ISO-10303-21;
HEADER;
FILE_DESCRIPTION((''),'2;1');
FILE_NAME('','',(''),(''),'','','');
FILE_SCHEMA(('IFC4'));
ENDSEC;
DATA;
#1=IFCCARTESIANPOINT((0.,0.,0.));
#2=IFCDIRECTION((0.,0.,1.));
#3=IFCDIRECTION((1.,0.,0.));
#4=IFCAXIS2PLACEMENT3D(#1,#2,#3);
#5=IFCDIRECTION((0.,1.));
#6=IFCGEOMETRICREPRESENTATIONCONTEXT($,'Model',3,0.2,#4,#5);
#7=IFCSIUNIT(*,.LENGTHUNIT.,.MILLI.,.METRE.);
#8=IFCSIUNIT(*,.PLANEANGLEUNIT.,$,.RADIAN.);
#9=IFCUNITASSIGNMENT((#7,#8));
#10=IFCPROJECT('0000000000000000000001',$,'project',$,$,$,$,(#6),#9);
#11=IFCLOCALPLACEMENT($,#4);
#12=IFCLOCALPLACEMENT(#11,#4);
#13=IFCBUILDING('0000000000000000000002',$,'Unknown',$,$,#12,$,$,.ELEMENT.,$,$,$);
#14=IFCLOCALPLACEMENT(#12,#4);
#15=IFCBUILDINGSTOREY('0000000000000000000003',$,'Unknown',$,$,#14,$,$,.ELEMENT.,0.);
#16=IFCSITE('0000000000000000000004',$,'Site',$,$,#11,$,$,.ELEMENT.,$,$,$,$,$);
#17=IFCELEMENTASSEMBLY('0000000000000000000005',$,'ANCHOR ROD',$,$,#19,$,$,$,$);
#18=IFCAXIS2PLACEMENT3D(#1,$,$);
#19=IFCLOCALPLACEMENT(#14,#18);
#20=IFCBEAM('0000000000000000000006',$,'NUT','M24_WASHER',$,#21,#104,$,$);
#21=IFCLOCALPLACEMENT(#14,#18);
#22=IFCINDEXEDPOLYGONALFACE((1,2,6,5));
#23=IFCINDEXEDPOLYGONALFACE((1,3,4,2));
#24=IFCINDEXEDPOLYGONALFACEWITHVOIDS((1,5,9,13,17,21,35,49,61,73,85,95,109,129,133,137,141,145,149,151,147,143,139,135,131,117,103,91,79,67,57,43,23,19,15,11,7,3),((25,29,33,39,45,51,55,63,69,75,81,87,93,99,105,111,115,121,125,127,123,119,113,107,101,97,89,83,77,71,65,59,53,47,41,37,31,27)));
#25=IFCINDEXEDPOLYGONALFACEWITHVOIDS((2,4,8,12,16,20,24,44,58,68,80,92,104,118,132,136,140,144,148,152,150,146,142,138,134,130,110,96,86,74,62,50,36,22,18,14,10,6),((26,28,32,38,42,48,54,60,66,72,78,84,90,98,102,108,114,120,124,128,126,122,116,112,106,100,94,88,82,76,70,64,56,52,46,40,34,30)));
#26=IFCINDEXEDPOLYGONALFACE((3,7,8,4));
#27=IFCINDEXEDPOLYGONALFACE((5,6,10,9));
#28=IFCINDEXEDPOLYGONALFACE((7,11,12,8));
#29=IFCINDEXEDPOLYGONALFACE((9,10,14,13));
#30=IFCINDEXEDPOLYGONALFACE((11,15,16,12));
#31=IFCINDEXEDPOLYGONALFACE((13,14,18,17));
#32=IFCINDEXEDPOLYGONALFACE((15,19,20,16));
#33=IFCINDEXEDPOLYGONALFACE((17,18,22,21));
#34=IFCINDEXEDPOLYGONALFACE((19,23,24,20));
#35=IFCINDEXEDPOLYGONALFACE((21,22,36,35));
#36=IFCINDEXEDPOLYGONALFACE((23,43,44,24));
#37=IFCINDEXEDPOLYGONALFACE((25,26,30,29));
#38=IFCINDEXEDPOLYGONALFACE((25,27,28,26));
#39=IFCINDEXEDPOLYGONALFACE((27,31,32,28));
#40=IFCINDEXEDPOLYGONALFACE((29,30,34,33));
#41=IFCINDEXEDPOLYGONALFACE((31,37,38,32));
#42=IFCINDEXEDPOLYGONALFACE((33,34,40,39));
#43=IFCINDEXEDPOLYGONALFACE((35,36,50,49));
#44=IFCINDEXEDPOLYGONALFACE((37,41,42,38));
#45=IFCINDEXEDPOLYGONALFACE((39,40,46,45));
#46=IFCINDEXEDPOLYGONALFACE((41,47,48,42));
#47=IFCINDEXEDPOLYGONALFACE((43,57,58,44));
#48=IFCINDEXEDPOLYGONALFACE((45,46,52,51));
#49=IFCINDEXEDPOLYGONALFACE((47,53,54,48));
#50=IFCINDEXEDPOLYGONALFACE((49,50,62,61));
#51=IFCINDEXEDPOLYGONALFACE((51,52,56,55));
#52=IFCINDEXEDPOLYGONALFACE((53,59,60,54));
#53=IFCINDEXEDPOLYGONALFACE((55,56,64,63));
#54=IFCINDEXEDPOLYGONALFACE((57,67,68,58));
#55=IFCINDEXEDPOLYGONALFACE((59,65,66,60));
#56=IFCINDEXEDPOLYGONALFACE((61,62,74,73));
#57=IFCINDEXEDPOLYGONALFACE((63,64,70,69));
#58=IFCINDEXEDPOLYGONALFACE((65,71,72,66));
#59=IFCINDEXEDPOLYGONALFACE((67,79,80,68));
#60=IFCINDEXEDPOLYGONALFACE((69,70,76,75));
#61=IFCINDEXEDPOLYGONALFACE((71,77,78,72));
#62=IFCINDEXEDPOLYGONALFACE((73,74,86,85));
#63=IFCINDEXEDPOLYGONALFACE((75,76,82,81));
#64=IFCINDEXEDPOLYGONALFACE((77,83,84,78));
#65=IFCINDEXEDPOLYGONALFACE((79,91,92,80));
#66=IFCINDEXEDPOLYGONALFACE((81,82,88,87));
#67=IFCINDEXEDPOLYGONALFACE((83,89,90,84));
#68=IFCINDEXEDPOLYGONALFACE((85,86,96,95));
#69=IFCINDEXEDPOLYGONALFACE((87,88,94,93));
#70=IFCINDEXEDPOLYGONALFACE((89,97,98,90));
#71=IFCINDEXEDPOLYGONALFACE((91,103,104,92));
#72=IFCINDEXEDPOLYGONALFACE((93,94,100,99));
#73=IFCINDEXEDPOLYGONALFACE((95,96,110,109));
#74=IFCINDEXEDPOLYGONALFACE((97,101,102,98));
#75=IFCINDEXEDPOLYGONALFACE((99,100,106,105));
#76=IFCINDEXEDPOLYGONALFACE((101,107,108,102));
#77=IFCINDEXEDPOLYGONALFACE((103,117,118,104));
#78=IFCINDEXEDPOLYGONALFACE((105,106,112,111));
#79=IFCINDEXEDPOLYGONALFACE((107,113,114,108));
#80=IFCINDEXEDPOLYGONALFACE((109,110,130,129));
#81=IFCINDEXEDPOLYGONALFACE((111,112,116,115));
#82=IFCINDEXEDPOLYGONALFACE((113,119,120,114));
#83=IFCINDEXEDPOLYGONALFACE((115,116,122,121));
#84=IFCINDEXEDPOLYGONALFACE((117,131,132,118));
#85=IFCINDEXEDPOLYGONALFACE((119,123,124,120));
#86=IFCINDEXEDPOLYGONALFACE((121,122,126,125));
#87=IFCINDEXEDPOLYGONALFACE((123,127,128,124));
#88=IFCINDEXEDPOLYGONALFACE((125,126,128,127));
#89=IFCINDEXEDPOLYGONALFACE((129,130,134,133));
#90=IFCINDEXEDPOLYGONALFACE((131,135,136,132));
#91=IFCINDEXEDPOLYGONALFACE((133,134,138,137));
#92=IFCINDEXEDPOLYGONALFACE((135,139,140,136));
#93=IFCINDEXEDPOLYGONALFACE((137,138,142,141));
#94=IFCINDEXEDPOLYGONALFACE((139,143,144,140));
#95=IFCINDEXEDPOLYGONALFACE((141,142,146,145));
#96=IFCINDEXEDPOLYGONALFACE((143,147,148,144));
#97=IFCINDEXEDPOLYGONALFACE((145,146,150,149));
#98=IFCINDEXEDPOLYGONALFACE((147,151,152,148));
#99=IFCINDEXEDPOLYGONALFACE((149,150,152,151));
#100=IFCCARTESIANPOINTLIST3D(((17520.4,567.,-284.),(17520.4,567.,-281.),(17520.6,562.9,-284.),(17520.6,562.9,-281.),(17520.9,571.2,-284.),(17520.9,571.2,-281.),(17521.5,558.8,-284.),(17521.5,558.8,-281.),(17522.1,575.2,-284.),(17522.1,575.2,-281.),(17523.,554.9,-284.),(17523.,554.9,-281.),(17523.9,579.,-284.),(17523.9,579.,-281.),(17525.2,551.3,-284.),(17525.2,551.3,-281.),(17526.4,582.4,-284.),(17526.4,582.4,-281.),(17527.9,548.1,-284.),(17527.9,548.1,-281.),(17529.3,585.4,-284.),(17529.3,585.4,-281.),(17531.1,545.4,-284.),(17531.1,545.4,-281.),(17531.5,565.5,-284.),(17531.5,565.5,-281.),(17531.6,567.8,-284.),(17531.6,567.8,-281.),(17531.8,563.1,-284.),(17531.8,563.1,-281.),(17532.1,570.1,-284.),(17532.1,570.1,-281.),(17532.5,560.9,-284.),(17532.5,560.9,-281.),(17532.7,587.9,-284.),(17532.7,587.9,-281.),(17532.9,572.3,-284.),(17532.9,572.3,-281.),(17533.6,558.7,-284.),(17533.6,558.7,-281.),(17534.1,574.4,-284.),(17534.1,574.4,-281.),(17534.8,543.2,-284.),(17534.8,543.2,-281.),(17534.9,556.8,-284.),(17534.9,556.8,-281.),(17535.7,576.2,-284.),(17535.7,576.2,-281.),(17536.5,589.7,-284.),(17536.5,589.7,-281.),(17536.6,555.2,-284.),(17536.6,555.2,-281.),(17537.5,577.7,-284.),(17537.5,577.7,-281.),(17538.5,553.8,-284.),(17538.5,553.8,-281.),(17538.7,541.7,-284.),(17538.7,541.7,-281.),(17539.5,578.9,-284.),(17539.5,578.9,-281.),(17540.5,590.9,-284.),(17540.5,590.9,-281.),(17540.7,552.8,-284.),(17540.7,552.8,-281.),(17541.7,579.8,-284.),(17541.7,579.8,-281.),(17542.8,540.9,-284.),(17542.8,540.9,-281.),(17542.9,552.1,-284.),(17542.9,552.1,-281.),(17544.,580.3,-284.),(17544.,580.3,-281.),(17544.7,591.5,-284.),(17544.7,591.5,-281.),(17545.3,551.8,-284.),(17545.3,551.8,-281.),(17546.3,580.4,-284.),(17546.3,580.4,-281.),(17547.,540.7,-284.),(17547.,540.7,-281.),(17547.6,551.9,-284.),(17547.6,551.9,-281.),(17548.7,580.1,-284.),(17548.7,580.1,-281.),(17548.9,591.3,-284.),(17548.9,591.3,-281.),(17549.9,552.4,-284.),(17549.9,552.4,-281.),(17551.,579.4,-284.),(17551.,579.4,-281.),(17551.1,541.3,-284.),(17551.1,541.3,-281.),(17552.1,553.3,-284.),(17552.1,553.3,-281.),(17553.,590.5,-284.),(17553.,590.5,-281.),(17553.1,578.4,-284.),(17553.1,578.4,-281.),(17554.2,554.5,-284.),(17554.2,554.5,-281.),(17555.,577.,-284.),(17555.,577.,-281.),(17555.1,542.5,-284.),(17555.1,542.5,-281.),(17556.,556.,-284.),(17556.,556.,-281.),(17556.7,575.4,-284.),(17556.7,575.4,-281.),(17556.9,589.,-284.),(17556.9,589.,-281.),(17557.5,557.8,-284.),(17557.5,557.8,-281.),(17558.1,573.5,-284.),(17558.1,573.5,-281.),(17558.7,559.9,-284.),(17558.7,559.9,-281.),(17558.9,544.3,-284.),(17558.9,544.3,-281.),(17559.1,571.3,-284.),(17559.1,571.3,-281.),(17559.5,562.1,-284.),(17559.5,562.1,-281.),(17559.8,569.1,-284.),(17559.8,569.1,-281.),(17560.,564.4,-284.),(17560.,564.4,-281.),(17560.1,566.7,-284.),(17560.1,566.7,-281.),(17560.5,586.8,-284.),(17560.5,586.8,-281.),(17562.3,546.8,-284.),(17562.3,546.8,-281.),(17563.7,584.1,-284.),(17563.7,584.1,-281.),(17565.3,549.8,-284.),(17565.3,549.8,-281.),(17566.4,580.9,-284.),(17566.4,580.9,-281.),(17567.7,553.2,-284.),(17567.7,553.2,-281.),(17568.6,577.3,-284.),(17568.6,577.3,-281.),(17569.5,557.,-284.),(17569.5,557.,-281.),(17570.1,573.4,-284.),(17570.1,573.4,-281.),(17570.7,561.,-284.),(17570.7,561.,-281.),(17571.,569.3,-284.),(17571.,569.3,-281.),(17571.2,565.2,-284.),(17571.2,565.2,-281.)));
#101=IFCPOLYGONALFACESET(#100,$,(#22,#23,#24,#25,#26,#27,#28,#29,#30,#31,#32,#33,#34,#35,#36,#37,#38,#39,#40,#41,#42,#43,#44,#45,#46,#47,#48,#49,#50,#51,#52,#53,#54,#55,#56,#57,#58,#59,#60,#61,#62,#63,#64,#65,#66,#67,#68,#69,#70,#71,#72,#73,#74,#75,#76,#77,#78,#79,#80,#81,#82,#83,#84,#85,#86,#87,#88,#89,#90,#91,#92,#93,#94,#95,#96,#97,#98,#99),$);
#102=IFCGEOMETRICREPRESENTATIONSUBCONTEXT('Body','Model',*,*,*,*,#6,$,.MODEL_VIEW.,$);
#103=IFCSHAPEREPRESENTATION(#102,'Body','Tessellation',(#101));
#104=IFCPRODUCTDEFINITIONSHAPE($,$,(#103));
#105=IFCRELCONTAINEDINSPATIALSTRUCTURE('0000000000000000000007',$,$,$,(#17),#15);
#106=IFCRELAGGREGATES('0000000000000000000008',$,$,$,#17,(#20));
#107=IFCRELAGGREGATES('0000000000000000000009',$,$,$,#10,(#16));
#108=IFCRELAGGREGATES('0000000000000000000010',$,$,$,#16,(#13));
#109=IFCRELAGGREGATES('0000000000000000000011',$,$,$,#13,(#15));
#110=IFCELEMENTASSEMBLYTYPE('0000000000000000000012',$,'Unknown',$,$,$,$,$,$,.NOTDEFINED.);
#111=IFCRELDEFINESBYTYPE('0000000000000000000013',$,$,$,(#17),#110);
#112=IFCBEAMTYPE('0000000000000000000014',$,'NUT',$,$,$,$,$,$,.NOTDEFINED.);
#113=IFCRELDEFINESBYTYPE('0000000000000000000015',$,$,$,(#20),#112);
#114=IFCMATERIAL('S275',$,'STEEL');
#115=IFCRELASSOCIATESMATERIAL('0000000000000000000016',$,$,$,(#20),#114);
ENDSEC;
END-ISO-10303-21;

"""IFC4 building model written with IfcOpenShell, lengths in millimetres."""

from ifc_helpers import new_model, si_unit, direction, frame, origin_with_axes, place, context, subcontext, project, spatial, polyline, outline, extrude, material, material_profile, profile_set, profile_usage, type_object, element, aggregate, save


model = new_model("IFC4")

# Units and contexts
model_context = context("Model", 3, precision=0.2, world=origin_with_axes(), true_north=direction((0.0, 1.0)))
body_context = subcontext(model_context, "Body", "Model", "MODEL_VIEW")
ifc_project = project(units=[si_unit("LENGTHUNIT", "METRE", prefix="MILLI"), si_unit("PLANEANGLEUNIT", "RADIAN")], contexts=[model_context])

# Site, building, storey
site_placement = place(None, origin_with_axes())
site = spatial("IfcSite", under=ifc_project, at=site_placement, Name="Site", CompositionType="ELEMENT")
building_placement = place(site_placement, origin_with_axes())
building = spatial("IfcBuilding", under=site, at=building_placement, Name="Unknown", CompositionType="ELEMENT")
storey_placement = place(building_placement, origin_with_axes())
storey = spatial("IfcBuildingStorey", under=building, at=storey_placement, Name="Unknown", CompositionType="ELEMENT", Elevation=0.0)

# Element assembly, beam
element_assembly_type = type_object("IfcElementAssemblyType", Name="Unknown", PredefinedType="NOTDEFINED")
assembly_1_placement = place(storey_placement, frame((17545.8, 566.1, -241.0), z_axis=(0.512428, -0.85873, 0.0), x_axis=(0.0, 0.0, -1.0)))
assembly_1 = element("IfcElementAssembly", 1, at=assembly_1_placement, inside=storey, type_object=element_assembly_type, Name="ANCHOR ROD")
ifc_material_1 = material(Name="S275", Category="STEEL")
ifc_material_profile_1 = material_profile(ifc_material_1, outline(polyline([(25.4, 0.0), (25.1, 4.2), (24.0, 8.2), (22.3, 12.1), (20.0, 15.6), (17.2, 18.7), (13.9, 21.3), (10.2, 23.3), (6.2, 24.6), (2.1, 25.3), (-2.1, 25.3), (-6.2, 24.6), (-10.2, 23.3), (-13.9, 21.3), (-17.2, 18.7), (-20.0, 15.6), (-22.3, 12.1), (-24.0, 8.2), (-25.1, 4.2), (-25.4, 0.0), (-25.1, -4.2), (-24.0, -8.2), (-22.3, -12.1), (-20.0, -15.6), (-17.2, -18.7), (-13.9, -21.3), (-10.2, -23.3), (-6.2, -24.6), (-2.1, -25.3), (2.1, -25.3), (6.2, -24.6), (10.2, -23.3), (13.9, -21.3), (17.2, -18.7), (20.0, -15.6), (22.3, -12.1), (24.0, -8.2), (25.1, -4.2), (25.4, 0.0)]), holes=[polyline([(0.0, 14.3), (2.4, 14.1), (4.6, 13.5), (6.8, 12.6), (8.8, 11.3), (10.5, 9.7), (12.0, 7.8), (13.1, 5.7), (13.9, 3.5), (14.2, 1.2), (14.2, -1.2), (13.9, -3.5), (13.1, -5.7), (12.0, -7.8), (10.5, -9.7), (8.8, -11.3), (6.8, -12.6), (4.6, -13.5), (2.4, -14.1), (0.0, -14.3), (-2.4, -14.1), (-4.6, -13.5), (-6.8, -12.6), (-8.8, -11.3), (-10.5, -9.7), (-12.0, -7.8), (-13.1, -5.7), (-13.9, -3.5), (-14.2, -1.2), (-14.2, 1.2), (-13.9, 3.5), (-13.1, 5.7), (-12.0, 7.8), (-10.5, 9.7), (-8.8, 11.3), (-6.8, 12.6), (-4.6, 13.5), (-2.4, 14.1), (0.0, 14.3)])]), Name="M24_WASHER")
ifc_profile_set_1 = profile_set([ifc_material_profile_1])
ifc_profile_usage_1 = profile_usage(ifc_profile_set_1, cardinal=5)
beam_type_1 = type_object("IfcBeamType", Name="NUT", PredefinedType="NOTDEFINED")
beam_1_placement = place(assembly_1_placement, frame((40.0, 0.0, 0.0), z_axis=(0.0, -0.003454, -0.999994), x_axis=(1.0, 0.0, 0.0)))
beam_1 = element("IfcBeam", 2, at=beam_1_placement, type_object=beam_type_1, material=ifc_profile_usage_1, Name="NUT", Description="M24_WASHER", context=body_context, shape_type="SolidModel", body=[
    extrude(outline(polyline([(25.4, 0.0), (25.1, 4.2), (24.0, 8.2), (22.3, 12.1), (20.0, 15.6), (17.2, 18.7), (13.9, 21.3), (10.2, 23.3), (6.2, 24.6), (2.1, 25.3), (-2.1, 25.3), (-6.2, 24.6), (-10.2, 23.3), (-13.9, 21.3), (-17.2, 18.7), (-20.0, 15.6), (-22.3, 12.1), (-24.0, 8.2), (-25.1, 4.2), (-25.4, 0.0), (-25.1, -4.2), (-24.0, -8.2), (-22.3, -12.1), (-20.0, -15.6), (-17.2, -18.7), (-13.9, -21.3), (-10.2, -23.3), (-6.2, -24.6), (-2.1, -25.3), (2.1, -25.3), (6.2, -24.6), (10.2, -23.3), (13.9, -21.3), (17.2, -18.7), (20.0, -15.6), (22.3, -12.1), (24.0, -8.2), (25.1, -4.2), (25.4, 0.0)]), holes=[polyline([(0.0, 14.3), (2.4, 14.1), (4.6, 13.5), (6.8, 12.6), (8.8, 11.3), (10.5, 9.7), (12.0, 7.8), (13.1, 5.7), (13.9, 3.5), (14.2, 1.2), (14.2, -1.2), (13.9, -3.5), (13.1, -5.7), (12.0, -7.8), (10.5, -9.7), (8.8, -11.3), (6.8, -12.6), (4.6, -13.5), (2.4, -14.1), (0.0, -14.3), (-2.4, -14.1), (-4.6, -13.5), (-6.8, -12.6), (-8.8, -11.3), (-10.5, -9.7), (-12.0, -7.8), (-13.1, -5.7), (-13.9, -3.5), (-14.2, -1.2), (-14.2, 1.2), (-13.9, 3.5), (-13.1, 5.7), (-12.0, 7.8), (-10.5, 9.7), (-8.8, 11.3), (-6.8, 12.6), (-4.6, 13.5), (-2.4, 14.1), (0.0, 14.3)])]), frame((0.0, 0.0, 0.0), z_axis=(-1.0, 0.0, 0.0), x_axis=(0.0, 0.0, 1.0)), (0.0, 0.0, -1.0), 3.0),
])

aggregate(assembly_1, [beam_1])

save(model, "model.ifc")
